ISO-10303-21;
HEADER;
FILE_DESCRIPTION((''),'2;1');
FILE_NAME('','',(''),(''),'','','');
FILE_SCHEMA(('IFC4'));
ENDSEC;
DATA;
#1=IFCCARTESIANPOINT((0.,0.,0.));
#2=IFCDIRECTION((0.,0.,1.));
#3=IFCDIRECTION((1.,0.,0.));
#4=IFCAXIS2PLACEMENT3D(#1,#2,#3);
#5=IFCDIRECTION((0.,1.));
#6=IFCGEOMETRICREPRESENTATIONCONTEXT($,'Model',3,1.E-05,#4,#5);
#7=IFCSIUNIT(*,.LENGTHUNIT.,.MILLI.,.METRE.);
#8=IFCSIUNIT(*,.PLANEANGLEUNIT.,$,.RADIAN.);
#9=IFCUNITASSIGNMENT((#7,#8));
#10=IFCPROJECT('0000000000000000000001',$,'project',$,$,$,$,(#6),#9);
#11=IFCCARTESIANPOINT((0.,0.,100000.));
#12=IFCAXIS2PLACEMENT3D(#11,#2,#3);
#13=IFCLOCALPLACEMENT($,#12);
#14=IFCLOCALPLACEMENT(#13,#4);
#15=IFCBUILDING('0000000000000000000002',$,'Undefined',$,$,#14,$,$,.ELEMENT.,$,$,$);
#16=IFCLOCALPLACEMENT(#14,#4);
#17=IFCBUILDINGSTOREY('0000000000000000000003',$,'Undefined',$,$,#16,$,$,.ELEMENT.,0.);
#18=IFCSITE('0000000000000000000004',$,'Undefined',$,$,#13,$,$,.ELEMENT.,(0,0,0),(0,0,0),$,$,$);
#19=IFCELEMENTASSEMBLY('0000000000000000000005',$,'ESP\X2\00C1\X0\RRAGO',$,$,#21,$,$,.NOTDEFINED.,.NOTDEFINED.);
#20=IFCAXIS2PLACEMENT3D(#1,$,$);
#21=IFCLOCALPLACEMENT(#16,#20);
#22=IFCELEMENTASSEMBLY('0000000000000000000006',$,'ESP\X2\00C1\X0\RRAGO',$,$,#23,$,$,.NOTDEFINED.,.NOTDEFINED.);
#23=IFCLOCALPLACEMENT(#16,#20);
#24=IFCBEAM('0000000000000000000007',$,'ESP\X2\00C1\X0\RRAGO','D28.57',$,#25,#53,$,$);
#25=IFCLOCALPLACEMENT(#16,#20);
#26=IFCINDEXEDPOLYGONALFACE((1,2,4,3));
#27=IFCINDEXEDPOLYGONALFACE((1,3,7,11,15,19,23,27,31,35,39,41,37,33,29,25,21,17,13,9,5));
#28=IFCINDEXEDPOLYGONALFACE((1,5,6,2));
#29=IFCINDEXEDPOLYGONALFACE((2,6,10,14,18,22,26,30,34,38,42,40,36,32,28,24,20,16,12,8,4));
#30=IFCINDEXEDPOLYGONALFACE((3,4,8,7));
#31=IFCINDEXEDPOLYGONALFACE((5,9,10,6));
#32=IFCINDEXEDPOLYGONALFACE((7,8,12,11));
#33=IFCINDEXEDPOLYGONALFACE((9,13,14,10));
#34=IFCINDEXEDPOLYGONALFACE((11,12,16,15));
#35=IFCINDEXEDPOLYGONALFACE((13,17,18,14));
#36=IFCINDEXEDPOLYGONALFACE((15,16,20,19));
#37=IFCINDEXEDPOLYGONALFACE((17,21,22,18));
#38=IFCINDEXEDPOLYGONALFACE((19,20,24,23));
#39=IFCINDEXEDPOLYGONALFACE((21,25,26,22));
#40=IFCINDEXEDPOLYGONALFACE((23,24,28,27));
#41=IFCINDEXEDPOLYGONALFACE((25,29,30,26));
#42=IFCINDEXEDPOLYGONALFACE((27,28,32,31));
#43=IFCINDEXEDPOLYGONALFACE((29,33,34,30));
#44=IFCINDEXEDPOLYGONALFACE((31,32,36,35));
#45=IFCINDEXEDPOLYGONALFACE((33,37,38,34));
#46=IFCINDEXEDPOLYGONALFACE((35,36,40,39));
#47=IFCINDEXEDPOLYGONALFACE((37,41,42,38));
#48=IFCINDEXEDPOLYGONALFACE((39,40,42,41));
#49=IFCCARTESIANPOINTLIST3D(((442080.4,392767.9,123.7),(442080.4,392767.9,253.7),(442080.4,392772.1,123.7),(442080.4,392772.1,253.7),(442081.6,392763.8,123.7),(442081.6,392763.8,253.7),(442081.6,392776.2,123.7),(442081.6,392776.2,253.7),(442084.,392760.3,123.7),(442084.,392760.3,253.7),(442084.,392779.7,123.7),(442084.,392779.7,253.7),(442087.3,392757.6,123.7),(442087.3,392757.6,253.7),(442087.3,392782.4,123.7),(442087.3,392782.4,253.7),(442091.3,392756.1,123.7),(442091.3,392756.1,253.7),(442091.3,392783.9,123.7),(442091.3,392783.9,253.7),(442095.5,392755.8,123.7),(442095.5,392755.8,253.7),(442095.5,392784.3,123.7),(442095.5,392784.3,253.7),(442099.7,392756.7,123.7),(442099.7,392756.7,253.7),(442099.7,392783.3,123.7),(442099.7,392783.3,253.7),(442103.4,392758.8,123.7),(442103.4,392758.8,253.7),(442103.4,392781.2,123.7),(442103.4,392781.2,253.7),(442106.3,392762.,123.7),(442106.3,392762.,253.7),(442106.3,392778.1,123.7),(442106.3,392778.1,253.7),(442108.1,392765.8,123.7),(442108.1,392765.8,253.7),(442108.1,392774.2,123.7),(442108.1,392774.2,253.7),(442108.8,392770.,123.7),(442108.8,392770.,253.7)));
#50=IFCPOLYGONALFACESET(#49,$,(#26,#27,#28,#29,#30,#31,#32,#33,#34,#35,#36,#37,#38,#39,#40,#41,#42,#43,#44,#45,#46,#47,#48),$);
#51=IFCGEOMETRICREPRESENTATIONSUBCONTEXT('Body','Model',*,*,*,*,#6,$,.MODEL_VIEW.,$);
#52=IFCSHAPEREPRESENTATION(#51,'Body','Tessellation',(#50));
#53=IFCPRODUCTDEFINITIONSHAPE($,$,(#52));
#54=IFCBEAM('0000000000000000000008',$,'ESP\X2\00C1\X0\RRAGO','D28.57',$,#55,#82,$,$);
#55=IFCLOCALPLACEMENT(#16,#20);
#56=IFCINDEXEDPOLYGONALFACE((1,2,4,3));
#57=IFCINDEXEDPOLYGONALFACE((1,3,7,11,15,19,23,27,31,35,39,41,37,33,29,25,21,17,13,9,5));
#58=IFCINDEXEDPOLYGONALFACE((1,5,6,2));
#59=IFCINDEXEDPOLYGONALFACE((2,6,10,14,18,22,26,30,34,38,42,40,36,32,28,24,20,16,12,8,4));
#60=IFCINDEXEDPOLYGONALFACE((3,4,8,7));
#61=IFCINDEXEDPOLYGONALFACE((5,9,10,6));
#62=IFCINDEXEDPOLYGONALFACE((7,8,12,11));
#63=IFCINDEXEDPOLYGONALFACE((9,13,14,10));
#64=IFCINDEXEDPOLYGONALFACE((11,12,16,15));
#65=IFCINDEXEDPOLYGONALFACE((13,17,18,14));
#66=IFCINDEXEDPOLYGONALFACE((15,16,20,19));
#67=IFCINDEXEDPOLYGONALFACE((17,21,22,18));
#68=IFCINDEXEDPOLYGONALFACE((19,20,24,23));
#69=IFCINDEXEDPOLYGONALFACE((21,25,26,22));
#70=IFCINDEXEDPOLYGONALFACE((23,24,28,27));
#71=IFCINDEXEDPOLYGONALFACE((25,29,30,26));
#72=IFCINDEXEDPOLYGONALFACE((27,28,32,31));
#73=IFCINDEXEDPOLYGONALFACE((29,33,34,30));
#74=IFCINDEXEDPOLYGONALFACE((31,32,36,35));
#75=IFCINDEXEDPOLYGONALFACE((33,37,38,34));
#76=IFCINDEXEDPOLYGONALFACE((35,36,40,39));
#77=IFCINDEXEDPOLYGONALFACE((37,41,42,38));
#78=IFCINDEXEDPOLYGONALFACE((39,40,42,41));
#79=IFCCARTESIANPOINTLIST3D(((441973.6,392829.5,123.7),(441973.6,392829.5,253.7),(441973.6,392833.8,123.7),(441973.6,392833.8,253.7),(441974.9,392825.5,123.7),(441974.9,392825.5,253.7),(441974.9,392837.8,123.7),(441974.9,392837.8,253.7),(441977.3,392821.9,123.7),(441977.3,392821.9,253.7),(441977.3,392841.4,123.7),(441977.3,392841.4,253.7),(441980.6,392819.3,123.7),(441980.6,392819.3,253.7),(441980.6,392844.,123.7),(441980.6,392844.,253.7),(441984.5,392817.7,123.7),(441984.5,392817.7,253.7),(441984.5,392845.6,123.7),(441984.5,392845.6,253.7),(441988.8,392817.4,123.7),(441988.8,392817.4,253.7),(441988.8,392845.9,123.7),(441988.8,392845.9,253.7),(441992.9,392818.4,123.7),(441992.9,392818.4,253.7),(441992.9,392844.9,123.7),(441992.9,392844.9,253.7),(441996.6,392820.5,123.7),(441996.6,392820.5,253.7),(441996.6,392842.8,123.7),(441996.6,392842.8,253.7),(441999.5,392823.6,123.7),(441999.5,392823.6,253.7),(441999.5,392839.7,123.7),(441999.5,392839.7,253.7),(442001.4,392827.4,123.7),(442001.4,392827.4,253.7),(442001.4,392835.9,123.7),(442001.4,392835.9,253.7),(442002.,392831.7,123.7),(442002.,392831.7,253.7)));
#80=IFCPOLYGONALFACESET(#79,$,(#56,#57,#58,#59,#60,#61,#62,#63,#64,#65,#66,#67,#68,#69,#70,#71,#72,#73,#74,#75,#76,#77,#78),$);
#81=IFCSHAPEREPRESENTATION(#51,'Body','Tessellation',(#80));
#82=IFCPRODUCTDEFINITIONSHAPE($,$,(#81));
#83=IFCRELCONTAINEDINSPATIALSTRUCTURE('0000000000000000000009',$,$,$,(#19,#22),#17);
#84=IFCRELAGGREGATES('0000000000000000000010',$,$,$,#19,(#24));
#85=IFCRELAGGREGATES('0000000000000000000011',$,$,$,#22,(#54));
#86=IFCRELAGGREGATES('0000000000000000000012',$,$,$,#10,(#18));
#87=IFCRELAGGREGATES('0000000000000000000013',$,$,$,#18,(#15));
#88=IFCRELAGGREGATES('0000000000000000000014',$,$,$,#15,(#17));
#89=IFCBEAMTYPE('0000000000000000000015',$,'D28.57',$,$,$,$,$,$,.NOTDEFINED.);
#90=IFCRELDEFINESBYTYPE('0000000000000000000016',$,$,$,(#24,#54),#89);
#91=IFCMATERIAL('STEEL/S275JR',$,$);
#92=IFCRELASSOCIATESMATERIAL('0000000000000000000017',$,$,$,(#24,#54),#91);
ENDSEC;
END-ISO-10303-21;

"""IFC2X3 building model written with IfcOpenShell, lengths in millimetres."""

from ifc_helpers import new_model, si_unit, direction, frame, origin_with_axes, origin_2d_with_axis, place, context, subcontext, project, spatial, circle, extrude, material, type_object, element, aggregate, save


model = new_model("IFC2X3")

# Units and contexts
model_context = context("Model", 3, precision=1e-05, world=origin_with_axes(), true_north=direction((0.0, 1.0)))
body_context = subcontext(model_context, "Body", "Model", "MODEL_VIEW")
ifc_project = project(units=[si_unit("LENGTHUNIT", "METRE", prefix="MILLI"), si_unit("PLANEANGLEUNIT", "RADIAN")], contexts=[model_context])

# Site, building, storey
site_placement = place(None, frame((0.0, 0.0, 100000.0), z_axis=(0.0, 0.0, 1.0), x_axis=(1.0, 0.0, 0.0)))
site = spatial("IfcSite", under=ifc_project, at=site_placement, Name="Undefined", CompositionType="ELEMENT", RefLatitude=(0, 0, 0), RefLongitude=(0, 0, 0))
building_placement = place(site_placement, origin_with_axes())
building = spatial("IfcBuilding", under=site, at=building_placement, Name="Undefined", CompositionType="ELEMENT")
storey_placement = place(building_placement, origin_with_axes())
storey = spatial("IfcBuildingStorey", under=building, at=storey_placement, Name="Undefined", CompositionType="ELEMENT", Elevation=0.0)

# Shared definitions
ifc_material_1 = material(Name="STEEL/S275JR")

# Element assemblies
assembly_1_placement = place(storey_placement, origin_with_axes())
assembly_1 = element("IfcElementAssembly", 1, at=assembly_1_placement, inside=storey, Name="ESPÁRRAGO", AssemblyPlace="NOTDEFINED", PredefinedType="NOTDEFINED")
assembly_2_placement = place(storey_placement, origin_with_axes())
assembly_2 = element("IfcElementAssembly", 2, at=assembly_2_placement, inside=storey, Name="ESPÁRRAGO", AssemblyPlace="NOTDEFINED", PredefinedType="NOTDEFINED")

# Beams
beam_type_1 = type_object("IfcBeamType", Name="D28.57", PredefinedType="NOTDEFINED")
beam_1_placement = place(assembly_1_placement, frame((442094.5, 392770.0, 253.7), z_axis=(0.866025, -0.5, 0.0), x_axis=(0.0, 0.0, -1.0)))
beam_1 = element("IfcBeam", 3, at=beam_1_placement, type_object=beam_type_1, material=ifc_material_1, Name="ESPÁRRAGO", Description="D28.57", context=body_context, shape_type="SweptSolid", body=[
    extrude(circle(Radius=14.3, at=origin_2d_with_axis()), frame((130.0, 0.0, 0.0), z_axis=(-1.0, 0.0, 0.0), x_axis=(0.0, -1.0, 0.0)), (0.0, 0.0, 1.0), 130.0),
])
aggregate(assembly_1, [beam_1])
beam_2_placement = place(assembly_2_placement, frame((441987.7, 392831.7, 253.7), z_axis=(0.866025, -0.5, 0.0), x_axis=(0.0, 0.0, -1.0)))
beam_2 = element("IfcBeam", 4, at=beam_2_placement, type_object=beam_type_1, material=ifc_material_1, Name="ESPÁRRAGO", Description="D28.57", context=body_context, shape_type="SweptSolid", body=[
    extrude(circle(Radius=14.3, at=origin_2d_with_axis()), frame((130.0, 0.0, 0.0), z_axis=(-1.0, 0.0, 0.0), x_axis=(0.0, -1.0, 0.0)), (0.0, 0.0, 1.0), 130.0),
])
aggregate(assembly_2, [beam_2])

save(model, "model.ifc")
